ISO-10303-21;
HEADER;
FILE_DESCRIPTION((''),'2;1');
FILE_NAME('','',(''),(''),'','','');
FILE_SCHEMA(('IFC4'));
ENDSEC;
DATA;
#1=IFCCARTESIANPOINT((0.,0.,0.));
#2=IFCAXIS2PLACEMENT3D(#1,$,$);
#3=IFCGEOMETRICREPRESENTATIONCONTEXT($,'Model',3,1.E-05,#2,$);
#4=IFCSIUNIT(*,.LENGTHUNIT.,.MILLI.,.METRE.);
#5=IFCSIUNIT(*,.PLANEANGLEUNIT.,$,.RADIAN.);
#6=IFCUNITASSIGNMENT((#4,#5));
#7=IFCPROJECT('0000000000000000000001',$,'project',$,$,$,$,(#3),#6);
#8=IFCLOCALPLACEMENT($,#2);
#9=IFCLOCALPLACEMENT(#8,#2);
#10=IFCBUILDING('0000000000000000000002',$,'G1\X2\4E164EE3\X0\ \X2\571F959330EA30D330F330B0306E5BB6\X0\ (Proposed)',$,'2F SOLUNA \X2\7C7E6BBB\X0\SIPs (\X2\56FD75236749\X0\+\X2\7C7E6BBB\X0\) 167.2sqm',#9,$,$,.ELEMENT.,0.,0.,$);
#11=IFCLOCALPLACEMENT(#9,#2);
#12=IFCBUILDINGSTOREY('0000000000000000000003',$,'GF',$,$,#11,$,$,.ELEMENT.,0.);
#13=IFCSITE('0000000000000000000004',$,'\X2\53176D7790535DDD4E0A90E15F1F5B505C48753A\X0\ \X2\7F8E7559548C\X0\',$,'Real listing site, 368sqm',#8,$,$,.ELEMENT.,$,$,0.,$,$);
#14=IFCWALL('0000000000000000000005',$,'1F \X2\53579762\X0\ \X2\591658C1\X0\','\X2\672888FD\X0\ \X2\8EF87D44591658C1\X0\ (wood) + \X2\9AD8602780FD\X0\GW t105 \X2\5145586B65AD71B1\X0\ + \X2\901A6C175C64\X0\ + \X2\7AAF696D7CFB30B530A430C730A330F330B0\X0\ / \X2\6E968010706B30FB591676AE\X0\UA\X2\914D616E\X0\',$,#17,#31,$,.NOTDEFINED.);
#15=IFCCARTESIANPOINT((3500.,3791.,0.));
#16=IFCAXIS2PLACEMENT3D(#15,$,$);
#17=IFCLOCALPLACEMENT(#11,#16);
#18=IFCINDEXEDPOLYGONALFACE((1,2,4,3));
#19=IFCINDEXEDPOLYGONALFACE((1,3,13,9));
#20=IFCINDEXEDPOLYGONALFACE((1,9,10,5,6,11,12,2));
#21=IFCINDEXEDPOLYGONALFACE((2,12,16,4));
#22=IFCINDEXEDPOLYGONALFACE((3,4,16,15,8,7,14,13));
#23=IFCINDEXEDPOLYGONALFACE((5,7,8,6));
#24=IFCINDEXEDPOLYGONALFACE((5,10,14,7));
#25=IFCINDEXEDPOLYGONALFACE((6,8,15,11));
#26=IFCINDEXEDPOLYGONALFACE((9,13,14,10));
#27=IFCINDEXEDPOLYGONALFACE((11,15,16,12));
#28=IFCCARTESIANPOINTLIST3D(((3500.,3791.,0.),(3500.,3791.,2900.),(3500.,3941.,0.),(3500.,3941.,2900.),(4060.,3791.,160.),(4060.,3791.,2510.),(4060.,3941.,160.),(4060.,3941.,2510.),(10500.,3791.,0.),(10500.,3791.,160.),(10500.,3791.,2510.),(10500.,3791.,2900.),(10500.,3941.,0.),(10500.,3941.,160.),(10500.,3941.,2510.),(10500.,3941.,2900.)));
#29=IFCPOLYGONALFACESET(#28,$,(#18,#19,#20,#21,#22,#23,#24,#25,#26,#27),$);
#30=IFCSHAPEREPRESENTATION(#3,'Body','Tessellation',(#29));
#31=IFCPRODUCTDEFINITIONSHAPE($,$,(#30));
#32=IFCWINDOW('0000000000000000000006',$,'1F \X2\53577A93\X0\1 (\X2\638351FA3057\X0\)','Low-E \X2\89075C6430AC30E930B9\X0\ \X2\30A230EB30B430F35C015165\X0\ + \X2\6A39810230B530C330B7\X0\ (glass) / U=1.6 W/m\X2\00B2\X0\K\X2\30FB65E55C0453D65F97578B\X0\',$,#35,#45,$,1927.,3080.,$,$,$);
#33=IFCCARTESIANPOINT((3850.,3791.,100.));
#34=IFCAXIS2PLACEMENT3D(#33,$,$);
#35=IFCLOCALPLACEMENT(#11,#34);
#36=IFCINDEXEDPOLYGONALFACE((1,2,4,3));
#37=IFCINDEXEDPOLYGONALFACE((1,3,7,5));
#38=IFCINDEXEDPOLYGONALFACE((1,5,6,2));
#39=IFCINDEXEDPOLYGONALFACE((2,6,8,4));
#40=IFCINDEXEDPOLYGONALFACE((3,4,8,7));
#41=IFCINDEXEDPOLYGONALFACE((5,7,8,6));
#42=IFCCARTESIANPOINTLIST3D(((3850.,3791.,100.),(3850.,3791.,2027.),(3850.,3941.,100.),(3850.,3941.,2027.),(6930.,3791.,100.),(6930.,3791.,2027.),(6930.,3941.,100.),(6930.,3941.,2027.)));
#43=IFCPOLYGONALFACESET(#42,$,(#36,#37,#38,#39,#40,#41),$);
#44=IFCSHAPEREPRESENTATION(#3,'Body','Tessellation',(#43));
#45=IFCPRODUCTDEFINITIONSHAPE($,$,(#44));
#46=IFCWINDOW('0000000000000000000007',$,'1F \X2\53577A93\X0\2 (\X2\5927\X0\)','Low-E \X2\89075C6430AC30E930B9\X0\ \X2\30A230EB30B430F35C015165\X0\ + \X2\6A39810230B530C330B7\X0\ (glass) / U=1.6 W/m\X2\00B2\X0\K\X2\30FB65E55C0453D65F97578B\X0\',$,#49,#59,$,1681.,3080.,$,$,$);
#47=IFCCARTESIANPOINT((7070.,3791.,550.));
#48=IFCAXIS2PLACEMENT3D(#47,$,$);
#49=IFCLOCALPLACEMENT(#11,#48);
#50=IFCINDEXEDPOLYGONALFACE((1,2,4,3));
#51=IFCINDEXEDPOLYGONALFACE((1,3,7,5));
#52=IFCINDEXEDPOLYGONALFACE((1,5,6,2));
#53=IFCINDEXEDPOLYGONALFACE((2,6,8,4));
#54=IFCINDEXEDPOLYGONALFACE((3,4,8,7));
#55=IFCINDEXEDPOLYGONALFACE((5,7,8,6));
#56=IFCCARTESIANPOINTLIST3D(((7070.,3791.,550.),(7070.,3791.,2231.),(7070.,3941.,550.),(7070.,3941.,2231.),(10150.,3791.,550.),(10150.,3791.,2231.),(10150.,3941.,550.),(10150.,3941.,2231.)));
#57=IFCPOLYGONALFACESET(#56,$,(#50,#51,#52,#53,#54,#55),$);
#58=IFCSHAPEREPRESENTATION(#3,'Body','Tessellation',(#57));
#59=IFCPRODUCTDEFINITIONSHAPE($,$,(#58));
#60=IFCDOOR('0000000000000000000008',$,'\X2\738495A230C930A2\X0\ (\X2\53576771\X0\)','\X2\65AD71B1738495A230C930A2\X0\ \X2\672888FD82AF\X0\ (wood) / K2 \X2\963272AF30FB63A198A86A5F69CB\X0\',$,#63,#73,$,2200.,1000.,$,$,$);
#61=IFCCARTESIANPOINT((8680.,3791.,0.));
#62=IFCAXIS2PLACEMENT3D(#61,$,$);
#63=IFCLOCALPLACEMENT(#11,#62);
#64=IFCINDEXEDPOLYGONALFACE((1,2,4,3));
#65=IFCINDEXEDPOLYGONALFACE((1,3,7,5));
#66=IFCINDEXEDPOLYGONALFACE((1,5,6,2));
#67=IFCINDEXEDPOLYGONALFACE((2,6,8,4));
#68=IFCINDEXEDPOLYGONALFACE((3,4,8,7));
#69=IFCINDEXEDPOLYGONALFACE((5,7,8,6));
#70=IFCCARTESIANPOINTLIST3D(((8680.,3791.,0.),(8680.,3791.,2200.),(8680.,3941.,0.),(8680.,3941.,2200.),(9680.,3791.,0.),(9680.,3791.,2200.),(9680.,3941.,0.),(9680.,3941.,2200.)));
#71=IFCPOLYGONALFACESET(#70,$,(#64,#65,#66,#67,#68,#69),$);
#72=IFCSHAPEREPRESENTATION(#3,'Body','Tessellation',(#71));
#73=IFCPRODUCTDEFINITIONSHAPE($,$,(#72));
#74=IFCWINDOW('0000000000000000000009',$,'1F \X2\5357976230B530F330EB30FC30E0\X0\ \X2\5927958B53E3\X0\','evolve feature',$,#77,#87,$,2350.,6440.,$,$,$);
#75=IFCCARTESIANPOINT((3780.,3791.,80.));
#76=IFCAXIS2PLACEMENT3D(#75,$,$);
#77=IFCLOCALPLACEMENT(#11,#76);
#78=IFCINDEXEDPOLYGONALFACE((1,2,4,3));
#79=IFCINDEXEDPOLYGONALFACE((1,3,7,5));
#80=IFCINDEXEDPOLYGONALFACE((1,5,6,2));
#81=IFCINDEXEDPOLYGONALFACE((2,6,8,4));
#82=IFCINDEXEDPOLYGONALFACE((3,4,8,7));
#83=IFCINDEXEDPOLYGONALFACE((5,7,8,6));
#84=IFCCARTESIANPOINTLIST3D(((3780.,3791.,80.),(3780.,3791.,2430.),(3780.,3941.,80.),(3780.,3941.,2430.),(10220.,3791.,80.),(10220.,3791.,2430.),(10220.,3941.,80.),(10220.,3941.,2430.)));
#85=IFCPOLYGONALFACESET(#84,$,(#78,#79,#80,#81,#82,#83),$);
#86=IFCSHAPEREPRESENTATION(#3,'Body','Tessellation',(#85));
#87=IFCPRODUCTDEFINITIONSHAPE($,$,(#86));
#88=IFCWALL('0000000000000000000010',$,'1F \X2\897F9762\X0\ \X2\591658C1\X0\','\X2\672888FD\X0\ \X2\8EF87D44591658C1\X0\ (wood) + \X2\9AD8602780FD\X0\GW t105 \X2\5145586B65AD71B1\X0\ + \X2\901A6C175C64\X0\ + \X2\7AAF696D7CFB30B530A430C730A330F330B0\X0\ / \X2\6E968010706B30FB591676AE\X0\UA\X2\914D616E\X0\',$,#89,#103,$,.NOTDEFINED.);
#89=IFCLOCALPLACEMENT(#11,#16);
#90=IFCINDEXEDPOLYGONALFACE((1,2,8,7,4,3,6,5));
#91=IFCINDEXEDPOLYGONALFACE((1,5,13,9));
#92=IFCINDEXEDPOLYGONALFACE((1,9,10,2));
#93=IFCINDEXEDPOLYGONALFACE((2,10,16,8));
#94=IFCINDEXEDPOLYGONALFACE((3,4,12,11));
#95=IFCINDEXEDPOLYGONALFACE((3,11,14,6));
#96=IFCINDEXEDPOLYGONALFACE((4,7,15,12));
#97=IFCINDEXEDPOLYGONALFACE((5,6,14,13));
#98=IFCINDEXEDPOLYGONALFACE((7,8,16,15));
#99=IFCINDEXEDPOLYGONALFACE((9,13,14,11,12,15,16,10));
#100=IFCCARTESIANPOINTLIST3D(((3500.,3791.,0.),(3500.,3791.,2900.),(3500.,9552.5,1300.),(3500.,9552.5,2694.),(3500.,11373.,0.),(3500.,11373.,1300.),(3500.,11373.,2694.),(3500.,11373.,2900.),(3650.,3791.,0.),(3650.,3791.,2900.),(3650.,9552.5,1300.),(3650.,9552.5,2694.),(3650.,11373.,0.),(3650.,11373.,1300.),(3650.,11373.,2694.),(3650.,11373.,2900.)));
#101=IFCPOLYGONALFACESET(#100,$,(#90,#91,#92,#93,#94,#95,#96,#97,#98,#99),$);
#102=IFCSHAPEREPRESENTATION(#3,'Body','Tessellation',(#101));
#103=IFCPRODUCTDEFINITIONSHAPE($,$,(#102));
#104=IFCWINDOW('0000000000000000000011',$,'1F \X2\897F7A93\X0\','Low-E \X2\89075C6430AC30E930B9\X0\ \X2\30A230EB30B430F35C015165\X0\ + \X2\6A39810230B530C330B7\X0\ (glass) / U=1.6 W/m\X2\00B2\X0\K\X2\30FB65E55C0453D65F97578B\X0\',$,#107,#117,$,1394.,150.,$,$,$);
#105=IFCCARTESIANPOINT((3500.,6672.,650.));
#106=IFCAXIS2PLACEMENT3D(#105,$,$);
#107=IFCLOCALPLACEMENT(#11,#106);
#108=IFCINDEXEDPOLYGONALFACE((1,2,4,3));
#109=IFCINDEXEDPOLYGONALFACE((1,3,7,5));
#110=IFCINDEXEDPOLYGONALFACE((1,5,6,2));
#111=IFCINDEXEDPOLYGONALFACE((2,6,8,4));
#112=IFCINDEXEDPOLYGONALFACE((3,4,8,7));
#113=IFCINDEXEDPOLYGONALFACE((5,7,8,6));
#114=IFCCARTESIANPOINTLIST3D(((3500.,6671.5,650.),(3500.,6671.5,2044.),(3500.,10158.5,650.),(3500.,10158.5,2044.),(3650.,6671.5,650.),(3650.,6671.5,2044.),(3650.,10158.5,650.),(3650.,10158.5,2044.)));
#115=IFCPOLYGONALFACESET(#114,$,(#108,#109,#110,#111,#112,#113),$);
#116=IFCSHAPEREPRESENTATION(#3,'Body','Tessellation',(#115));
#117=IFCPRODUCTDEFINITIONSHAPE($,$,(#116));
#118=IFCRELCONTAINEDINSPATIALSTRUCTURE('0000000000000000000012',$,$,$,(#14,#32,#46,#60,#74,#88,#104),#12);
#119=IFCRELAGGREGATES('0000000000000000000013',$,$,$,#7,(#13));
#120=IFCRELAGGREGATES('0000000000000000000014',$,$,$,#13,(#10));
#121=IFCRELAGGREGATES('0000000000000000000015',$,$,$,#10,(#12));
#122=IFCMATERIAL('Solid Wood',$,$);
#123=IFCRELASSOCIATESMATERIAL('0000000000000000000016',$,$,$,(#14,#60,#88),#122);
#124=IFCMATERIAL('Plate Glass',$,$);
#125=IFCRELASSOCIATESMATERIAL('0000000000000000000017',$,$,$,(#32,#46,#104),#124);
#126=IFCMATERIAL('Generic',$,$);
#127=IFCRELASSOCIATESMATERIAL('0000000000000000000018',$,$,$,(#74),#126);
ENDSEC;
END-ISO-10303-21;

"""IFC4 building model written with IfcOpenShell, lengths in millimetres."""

from ifc_helpers import new_model, si_unit, frame, frame_2d, origin, place, context, project, spatial, rectangle, extrude, material, element, fill, save


model = new_model("IFC4")

# Units and contexts
model_context = context("Model", 3, precision=1e-05, world=origin())
ifc_project = project(units=[si_unit("LENGTHUNIT", "METRE", prefix="MILLI"), si_unit("PLANEANGLEUNIT", "RADIAN")], contexts=[model_context])

# Site, building, storey
site_placement = place(None, origin())
site = spatial("IfcSite", under=ifc_project, at=site_placement, Name="北海道川上郡弟子屈町 美留和", ObjectType="Real listing site, 368sqm", CompositionType="ELEMENT", RefElevation=0.0)
building_placement = place(site_placement, origin())
building = spatial("IfcBuilding", under=site, at=building_placement, Name="G1世代 土間リビングの家 (Proposed)", ObjectType="2F SOLUNA 籾殻SIPs (国産杉+籾殻) 167.2sqm", CompositionType="ELEMENT", ElevationOfRefHeight=0.0, ElevationOfTerrain=0.0)
storey_placement = place(building_placement, origin())
storey = spatial("IfcBuildingStorey", under=building, at=storey_placement, Name="GF", CompositionType="ELEMENT", Elevation=0.0)

# Shared definitions
ifc_material_1 = material(Name="Solid Wood")
ifc_material_2 = material(Name="Generic")

# Wall, openings, windows, door
wall_1_placement = place(storey_placement, frame((3500.0, 3791.0, 0.0)))
wall_1 = element("IfcWall", 1, at=wall_1_placement, inside=storey, material=ifc_material_1, Name="1F 南面 外壁", Description="木製 軸組外壁 (wood) + 高性能GW t105 充填断熱 + 通気層 + 窯業系サイディング / 準耐火・外皮UA配慮", PredefinedType="NOTDEFINED", context=model_context, shape_type="SweptSolid", body=[
    extrude(rectangle(XDim=7000.0, YDim=150.0, at=frame_2d((3500.0, 75.0))), frame((3500.0, 3791.0, 0.0)), (0.0, 0.0, 1.0), 2900.0),
])
opening_1_placement = place(storey_placement, frame((3850.0, 3791.0, 100.0)))
opening_1 = element("IfcOpeningElement", 2, at=opening_1_placement, cuts=wall_1, PredefinedType="NOTDEFINED", context=model_context, shape_type="SweptSolid", body=[
    extrude(rectangle(XDim=3080.0, YDim=150.0, at=frame_2d((1540.0, 75.0))), frame((3850.0, 3791.0, 100.0)), (0.0, 0.0, 1.0), 1927.0),
])
opening_2_placement = place(storey_placement, frame((7070.0, 3791.0, 550.0)))
opening_2 = element("IfcOpeningElement", 3, at=opening_2_placement, cuts=wall_1, PredefinedType="NOTDEFINED", context=model_context, shape_type="SweptSolid", body=[
    extrude(rectangle(XDim=3080.0, YDim=150.0, at=frame_2d((1540.0, 75.0))), frame((7070.0, 3791.0, 550.0)), (0.0, 0.0, 1.0), 1681.0),
])
opening_3_placement = place(storey_placement, frame((8680.0, 3791.0, 0.0)))
opening_3 = element("IfcOpeningElement", 4, at=opening_3_placement, cuts=wall_1, PredefinedType="NOTDEFINED", context=model_context, shape_type="SweptSolid", body=[
    extrude(rectangle(XDim=1000.0, YDim=150.0, at=frame_2d((500.0, 75.0))), frame((8680.0, 3791.0, 0.0)), (0.0, 0.0, 1.0), 2200.0),
])
opening_4_placement = place(storey_placement, frame((3780.0, 3791.0, 80.0)))
opening_4 = element("IfcOpeningElement", 5, at=opening_4_placement, cuts=wall_1, PredefinedType="NOTDEFINED", context=model_context, shape_type="SweptSolid", body=[
    extrude(rectangle(XDim=6440.0, YDim=150.0, at=frame_2d((3220.0, 75.0))), frame((3780.0, 3791.0, 80.0)), (0.0, 0.0, 1.0), 2350.0),
])
ifc_material_3 = material(Name="Plate Glass")
window_1_placement = place(storey_placement, frame((3850.0, 3791.0, 100.0)))
window_1 = element("IfcWindow", 6, at=window_1_placement, inside=storey, material=ifc_material_3, Name="1F 南窓1 (掃出し)", Description="Low-E 複層ガラス アルゴン封入 + 樹脂サッシ (glass) / U=1.6 W/m²K・日射取得型", OverallHeight=1927.0, OverallWidth=3080.0, context=model_context, shape_type="SweptSolid", body=[
    extrude(rectangle(XDim=3080.0, YDim=150.0, at=frame_2d((1540.0, 75.0))), frame((3850.0, 3791.0, 100.0)), (0.0, 0.0, 1.0), 1927.0),
])
fill(opening_1, window_1)
window_2_placement = place(storey_placement, frame((7070.0, 3791.0, 550.0)))
window_2 = element("IfcWindow", 7, at=window_2_placement, inside=storey, material=ifc_material_3, Name="1F 南窓2 (大)", Description="Low-E 複層ガラス アルゴン封入 + 樹脂サッシ (glass) / U=1.6 W/m²K・日射取得型", OverallHeight=1681.0, OverallWidth=3080.0, context=model_context, shape_type="SweptSolid", body=[
    extrude(rectangle(XDim=3080.0, YDim=150.0, at=frame_2d((1540.0, 75.0))), frame((7070.0, 3791.0, 550.0)), (0.0, 0.0, 1.0), 1681.0),
])
fill(opening_2, window_2)
door_placement = place(storey_placement, frame((8680.0, 3791.0, 0.0)))
door = element("IfcDoor", 8, at=door_placement, inside=storey, material=ifc_material_1, Name="玄関ドア (南東)", Description="断熱玄関ドア 木製芯 (wood) / K2 防犯・採風機構", OverallHeight=2200.0, OverallWidth=1000.0, context=model_context, shape_type="SweptSolid", body=[
    extrude(rectangle(XDim=1000.0, YDim=150.0, at=frame_2d((500.0, 75.0))), frame((8680.0, 3791.0, 0.0)), (0.0, 0.0, 1.0), 2200.0),
])
fill(opening_3, door)
window_3_placement = place(storey_placement, frame((3780.0, 3791.0, 80.0)))
window_3 = element("IfcWindow", 9, at=window_3_placement, inside=storey, material=ifc_material_2, Name="1F 南面サンルーム 大開口", Description="evolve feature", OverallHeight=2350.0, OverallWidth=6440.0, context=model_context, shape_type="SweptSolid", body=[
    extrude(rectangle(XDim=6440.0, YDim=150.0, at=frame_2d((3220.0, 75.0))), frame((3780.0, 3791.0, 80.0)), (0.0, 0.0, 1.0), 2350.0),
])
fill(opening_4, window_3)

# Wall, opening, window
wall_2_placement = place(storey_placement, frame((3500.0, 3791.0, 0.0)))
wall_2 = element("IfcWall", 10, at=wall_2_placement, inside=storey, material=ifc_material_1, Name="1F 西面 外壁", Description="木製 軸組外壁 (wood) + 高性能GW t105 充填断熱 + 通気層 + 窯業系サイディング / 準耐火・外皮UA配慮", PredefinedType="NOTDEFINED", context=model_context, shape_type="SweptSolid", body=[
    extrude(rectangle(XDim=150.0, YDim=7582.0, at=frame_2d((75.0, 3791.0))), frame((3500.0, 3791.0, 0.0)), (0.0, 0.0, 1.0), 2900.0),
])
opening_5_placement = place(storey_placement, frame((3500.0, 6672.0, 650.0)))
opening_5 = element("IfcOpeningElement", 11, at=opening_5_placement, cuts=wall_2, PredefinedType="NOTDEFINED", context=model_context, shape_type="SweptSolid", body=[
    extrude(rectangle(XDim=150.0, YDim=3487.0, at=frame_2d((75.0, 1743.0))), frame((3500.0, 6672.0, 650.0)), (0.0, 0.0, 1.0), 1394.0),
])
window_4_placement = place(storey_placement, frame((3500.0, 6672.0, 650.0)))
window_4 = element("IfcWindow", 12, at=window_4_placement, inside=storey, material=ifc_material_3, Name="1F 西窓", Description="Low-E 複層ガラス アルゴン封入 + 樹脂サッシ (glass) / U=1.6 W/m²K・日射取得型", OverallHeight=1394.0, OverallWidth=150.0, context=model_context, shape_type="SweptSolid", body=[
    extrude(rectangle(XDim=150.0, YDim=3487.0, at=frame_2d((75.0, 1743.0))), frame((3500.0, 6672.0, 650.0)), (0.0, 0.0, 1.0), 1394.0),
])
fill(opening_5, window_4)

save(model, "model.ifc")
